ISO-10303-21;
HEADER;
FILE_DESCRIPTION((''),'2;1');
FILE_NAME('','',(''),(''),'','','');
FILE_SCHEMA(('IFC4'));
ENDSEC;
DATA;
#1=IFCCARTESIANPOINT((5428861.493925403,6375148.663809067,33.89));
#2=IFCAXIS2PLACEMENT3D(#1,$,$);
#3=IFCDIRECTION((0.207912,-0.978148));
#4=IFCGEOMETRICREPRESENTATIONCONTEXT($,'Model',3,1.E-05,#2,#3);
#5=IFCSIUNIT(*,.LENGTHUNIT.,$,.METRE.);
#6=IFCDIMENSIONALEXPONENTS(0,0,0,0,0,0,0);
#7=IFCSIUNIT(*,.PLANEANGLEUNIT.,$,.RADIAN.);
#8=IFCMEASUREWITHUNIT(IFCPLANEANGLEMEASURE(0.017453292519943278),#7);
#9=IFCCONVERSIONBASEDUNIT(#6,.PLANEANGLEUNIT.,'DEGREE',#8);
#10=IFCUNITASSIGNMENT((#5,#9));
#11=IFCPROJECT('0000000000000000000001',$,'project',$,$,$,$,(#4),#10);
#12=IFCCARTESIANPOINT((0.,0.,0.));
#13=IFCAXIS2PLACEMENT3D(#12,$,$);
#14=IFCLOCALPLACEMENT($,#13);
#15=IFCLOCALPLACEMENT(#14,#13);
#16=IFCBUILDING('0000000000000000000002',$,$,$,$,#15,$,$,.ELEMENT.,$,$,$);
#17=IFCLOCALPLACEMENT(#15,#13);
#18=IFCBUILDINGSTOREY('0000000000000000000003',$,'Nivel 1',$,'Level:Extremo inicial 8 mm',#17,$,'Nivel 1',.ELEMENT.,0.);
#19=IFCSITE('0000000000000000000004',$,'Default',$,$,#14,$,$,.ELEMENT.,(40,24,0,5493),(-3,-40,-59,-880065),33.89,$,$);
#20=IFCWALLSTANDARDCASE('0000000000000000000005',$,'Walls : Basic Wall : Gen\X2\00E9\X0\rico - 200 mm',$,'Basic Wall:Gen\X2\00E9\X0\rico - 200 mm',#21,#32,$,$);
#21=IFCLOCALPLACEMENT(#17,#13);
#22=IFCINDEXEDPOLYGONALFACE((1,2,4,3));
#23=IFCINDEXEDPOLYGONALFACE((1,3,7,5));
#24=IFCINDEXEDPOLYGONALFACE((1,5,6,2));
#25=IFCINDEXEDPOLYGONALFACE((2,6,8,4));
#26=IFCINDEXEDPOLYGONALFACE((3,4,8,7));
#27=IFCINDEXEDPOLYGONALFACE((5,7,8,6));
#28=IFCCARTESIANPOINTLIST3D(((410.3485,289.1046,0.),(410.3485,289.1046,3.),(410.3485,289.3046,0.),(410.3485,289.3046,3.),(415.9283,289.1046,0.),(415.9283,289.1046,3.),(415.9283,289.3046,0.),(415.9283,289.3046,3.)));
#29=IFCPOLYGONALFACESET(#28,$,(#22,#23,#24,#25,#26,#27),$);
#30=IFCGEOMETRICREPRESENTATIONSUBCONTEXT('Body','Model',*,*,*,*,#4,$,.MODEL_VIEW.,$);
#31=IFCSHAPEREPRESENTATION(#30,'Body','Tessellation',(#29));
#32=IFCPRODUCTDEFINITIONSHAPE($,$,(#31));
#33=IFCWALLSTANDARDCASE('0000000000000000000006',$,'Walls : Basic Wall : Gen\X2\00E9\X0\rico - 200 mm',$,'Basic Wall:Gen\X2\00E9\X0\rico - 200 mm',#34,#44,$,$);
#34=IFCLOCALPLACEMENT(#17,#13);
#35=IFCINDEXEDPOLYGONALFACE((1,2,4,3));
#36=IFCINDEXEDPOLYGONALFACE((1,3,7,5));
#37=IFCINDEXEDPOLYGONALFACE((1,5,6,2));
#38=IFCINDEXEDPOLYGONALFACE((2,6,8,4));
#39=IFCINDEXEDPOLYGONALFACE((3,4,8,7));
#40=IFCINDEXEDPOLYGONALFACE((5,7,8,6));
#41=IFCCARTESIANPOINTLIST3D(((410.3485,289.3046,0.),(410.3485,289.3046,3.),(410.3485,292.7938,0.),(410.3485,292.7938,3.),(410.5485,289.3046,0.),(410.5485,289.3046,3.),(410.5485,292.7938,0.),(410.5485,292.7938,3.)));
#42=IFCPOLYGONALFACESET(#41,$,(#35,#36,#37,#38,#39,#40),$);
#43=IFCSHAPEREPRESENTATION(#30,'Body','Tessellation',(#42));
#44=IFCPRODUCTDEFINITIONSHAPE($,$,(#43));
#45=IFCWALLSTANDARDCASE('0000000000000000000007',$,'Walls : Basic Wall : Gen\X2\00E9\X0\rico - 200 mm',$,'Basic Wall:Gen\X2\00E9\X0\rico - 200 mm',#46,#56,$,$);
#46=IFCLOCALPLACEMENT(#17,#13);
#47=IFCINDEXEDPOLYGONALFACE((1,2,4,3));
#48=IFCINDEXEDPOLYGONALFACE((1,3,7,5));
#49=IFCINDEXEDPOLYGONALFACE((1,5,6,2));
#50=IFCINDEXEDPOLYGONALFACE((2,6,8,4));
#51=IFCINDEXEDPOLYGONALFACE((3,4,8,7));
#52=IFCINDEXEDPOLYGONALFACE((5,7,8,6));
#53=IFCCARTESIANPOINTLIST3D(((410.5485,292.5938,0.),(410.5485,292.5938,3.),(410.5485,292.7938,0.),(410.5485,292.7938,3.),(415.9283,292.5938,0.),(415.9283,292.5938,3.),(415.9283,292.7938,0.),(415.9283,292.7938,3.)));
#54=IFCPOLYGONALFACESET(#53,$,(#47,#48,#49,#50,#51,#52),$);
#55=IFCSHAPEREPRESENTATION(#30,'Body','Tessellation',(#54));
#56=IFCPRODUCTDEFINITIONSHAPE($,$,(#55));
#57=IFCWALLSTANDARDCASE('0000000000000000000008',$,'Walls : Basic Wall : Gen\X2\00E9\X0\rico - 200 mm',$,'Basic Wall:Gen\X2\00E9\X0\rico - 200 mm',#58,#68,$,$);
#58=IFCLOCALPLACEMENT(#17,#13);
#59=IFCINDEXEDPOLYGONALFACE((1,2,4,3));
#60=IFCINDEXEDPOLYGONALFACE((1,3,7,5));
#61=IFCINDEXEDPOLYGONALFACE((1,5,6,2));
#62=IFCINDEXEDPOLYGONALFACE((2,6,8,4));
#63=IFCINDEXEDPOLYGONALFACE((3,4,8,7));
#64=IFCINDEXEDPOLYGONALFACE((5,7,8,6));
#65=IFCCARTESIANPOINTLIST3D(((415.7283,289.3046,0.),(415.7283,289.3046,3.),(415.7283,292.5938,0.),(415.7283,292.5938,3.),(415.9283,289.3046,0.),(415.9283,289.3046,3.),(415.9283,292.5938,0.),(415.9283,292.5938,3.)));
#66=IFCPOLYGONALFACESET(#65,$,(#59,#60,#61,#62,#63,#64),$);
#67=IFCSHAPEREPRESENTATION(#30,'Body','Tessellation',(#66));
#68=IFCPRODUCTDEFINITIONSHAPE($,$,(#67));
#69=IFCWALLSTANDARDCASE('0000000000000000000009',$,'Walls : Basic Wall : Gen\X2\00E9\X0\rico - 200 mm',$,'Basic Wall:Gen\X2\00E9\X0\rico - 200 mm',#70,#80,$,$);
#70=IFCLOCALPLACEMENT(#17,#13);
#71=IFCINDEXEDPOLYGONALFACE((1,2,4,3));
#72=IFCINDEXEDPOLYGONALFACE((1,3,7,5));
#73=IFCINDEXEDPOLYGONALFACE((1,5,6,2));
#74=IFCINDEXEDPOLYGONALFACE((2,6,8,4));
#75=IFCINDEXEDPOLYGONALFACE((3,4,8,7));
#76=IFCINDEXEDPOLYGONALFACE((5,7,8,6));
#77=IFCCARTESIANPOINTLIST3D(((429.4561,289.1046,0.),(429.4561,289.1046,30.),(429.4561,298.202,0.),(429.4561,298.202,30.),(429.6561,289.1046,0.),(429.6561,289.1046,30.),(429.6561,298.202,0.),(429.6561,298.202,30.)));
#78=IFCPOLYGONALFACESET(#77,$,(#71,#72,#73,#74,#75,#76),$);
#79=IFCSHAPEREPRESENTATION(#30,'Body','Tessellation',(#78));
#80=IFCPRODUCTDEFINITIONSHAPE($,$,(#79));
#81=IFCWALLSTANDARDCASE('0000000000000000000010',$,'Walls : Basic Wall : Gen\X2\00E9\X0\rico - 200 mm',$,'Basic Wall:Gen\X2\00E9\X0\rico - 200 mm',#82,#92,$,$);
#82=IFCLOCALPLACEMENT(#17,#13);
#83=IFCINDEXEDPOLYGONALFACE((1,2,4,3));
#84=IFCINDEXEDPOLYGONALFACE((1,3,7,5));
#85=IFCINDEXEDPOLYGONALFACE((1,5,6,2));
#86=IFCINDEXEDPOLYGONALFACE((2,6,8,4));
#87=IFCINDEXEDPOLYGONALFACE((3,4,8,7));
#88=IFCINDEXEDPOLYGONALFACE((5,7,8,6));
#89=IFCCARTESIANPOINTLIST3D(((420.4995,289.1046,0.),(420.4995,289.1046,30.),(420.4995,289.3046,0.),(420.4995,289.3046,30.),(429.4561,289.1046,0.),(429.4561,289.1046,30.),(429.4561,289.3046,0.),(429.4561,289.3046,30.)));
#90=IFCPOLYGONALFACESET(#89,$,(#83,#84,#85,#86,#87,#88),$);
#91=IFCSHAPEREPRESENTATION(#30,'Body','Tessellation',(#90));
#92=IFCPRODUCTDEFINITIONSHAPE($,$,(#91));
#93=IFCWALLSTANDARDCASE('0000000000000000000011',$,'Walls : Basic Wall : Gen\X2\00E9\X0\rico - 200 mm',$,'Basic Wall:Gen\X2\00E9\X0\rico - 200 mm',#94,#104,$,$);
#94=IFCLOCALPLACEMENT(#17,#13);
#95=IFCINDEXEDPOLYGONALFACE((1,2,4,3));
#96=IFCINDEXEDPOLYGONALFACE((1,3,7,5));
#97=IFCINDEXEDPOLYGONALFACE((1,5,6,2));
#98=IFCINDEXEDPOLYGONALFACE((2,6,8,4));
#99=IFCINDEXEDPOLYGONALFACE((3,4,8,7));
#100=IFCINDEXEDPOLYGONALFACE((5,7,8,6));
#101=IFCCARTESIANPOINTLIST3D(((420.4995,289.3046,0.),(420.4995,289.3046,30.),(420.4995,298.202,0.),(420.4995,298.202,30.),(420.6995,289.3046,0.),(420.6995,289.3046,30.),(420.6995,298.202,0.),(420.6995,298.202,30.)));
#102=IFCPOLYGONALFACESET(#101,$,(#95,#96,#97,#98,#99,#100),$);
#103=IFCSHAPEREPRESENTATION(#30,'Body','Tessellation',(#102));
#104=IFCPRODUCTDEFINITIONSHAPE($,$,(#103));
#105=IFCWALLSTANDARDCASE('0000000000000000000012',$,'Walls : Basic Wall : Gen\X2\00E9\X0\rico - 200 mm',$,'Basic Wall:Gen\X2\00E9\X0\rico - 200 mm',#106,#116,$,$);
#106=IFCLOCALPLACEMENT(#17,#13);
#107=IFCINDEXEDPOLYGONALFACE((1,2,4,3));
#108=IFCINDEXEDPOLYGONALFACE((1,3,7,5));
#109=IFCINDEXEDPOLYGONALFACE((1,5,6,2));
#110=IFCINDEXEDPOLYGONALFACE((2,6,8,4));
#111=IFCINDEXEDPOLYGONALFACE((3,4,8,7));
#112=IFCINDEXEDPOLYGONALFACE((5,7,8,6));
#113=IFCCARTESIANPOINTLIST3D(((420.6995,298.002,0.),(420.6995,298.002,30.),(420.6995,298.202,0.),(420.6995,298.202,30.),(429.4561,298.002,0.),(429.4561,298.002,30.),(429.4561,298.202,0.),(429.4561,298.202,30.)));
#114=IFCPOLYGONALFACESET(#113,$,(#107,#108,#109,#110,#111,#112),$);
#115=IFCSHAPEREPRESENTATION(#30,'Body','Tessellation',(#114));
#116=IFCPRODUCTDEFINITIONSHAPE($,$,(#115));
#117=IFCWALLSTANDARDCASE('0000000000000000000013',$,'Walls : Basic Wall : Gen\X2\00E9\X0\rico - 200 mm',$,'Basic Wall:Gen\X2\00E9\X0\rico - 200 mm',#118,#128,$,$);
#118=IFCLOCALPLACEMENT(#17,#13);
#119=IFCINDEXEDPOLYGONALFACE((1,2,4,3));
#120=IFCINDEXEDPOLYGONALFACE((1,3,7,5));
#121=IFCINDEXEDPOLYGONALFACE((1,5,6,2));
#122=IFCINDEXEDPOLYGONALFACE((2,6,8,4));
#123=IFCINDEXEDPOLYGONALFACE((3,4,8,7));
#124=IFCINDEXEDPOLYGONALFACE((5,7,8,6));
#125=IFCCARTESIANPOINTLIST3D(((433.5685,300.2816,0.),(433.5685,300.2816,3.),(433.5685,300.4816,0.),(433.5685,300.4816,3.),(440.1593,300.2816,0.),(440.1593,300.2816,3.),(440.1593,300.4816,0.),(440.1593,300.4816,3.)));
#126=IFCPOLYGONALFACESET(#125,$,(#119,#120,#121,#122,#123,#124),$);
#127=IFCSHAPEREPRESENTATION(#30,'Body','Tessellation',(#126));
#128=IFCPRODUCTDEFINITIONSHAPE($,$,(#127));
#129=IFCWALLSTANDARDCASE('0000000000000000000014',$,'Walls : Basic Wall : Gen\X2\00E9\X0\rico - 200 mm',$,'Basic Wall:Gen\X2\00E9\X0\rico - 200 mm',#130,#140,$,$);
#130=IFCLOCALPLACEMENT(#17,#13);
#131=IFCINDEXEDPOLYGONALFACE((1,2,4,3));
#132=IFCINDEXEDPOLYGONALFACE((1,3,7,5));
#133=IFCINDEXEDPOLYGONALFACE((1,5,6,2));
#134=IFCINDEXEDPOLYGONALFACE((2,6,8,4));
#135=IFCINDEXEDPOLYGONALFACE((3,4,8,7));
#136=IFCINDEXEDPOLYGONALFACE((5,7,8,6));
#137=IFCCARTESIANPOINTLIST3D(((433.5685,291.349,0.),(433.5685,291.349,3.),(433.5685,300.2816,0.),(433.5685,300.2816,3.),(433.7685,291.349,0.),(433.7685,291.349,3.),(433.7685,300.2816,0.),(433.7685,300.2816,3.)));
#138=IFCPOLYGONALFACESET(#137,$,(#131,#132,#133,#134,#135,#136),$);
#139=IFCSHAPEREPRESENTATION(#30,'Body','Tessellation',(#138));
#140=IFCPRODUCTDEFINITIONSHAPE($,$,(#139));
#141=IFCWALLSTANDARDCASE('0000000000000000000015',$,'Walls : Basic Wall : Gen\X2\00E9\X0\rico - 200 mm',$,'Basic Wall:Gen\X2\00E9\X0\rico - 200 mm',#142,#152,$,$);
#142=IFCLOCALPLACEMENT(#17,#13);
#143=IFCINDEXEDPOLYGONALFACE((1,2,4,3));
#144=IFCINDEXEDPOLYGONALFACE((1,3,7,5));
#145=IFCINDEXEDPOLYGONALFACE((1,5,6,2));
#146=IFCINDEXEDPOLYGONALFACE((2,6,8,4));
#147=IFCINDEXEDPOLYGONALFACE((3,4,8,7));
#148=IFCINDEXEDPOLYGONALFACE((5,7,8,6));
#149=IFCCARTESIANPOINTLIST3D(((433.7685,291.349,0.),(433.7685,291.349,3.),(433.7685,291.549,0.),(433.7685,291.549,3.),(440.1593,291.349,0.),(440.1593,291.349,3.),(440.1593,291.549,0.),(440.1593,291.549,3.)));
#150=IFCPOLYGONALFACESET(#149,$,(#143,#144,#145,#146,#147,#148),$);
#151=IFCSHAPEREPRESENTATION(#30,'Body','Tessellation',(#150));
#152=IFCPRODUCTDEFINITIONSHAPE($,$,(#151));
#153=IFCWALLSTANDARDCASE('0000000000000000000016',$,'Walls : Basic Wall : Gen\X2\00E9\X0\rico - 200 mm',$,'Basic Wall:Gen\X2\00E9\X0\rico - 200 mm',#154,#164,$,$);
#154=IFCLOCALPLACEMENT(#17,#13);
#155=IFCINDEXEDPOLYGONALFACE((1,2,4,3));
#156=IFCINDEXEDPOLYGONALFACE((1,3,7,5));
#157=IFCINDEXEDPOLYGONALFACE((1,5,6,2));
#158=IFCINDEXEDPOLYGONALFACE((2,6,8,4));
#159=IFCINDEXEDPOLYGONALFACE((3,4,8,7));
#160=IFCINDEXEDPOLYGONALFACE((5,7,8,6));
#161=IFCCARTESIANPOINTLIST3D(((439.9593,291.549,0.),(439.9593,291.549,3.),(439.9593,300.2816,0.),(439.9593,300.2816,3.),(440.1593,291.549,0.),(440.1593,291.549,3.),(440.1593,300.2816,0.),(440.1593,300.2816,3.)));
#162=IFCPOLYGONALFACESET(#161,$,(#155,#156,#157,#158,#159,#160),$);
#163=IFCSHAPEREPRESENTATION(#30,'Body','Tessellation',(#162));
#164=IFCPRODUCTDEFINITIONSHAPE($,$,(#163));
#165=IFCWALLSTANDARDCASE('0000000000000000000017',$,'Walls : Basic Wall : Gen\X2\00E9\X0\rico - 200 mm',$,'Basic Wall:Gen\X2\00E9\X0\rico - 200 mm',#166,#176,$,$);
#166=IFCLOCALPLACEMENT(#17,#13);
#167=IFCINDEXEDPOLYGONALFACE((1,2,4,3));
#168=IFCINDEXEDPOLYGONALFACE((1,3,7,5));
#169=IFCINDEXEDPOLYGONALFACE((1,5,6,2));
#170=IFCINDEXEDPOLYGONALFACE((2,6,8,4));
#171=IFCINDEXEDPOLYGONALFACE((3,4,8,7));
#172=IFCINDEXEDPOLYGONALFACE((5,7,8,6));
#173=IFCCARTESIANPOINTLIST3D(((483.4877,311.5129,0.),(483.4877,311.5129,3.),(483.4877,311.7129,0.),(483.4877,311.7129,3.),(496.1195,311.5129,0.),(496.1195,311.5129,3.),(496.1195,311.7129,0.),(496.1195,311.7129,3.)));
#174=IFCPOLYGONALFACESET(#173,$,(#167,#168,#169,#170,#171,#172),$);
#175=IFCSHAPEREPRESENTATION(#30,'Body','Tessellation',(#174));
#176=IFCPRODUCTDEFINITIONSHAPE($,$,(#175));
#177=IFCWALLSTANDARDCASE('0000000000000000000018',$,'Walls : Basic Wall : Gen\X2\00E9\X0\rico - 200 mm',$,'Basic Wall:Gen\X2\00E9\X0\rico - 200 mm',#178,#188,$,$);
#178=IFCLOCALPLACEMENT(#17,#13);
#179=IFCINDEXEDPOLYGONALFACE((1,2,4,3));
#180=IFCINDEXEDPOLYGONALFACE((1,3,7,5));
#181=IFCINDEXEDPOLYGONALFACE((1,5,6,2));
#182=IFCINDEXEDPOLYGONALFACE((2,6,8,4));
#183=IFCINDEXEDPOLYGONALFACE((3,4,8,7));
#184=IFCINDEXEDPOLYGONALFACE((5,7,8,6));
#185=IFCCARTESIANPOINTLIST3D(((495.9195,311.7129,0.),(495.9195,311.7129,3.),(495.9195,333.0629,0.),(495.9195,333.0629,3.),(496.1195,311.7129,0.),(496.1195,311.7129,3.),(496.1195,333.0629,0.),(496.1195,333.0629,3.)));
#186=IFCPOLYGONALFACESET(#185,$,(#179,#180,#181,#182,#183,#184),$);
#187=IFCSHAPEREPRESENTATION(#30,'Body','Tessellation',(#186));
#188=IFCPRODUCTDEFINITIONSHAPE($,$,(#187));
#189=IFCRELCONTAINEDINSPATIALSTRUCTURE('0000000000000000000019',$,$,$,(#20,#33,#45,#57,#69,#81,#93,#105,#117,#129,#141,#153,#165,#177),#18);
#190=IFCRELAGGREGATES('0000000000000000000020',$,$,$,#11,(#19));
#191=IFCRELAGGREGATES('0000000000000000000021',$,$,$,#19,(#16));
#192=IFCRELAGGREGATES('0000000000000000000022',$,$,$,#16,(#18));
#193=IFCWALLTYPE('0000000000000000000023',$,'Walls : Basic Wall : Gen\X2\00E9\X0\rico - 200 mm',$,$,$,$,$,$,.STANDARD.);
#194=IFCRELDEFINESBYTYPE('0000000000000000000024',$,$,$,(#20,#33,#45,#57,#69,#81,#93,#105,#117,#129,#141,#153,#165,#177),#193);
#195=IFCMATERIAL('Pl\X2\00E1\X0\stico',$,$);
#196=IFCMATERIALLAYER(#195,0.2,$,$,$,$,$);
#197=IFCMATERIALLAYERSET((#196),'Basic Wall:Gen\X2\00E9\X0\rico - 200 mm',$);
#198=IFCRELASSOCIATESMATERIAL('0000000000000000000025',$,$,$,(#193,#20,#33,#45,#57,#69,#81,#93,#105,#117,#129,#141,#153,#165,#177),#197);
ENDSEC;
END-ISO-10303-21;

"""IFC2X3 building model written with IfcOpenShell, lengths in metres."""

from ifc_helpers import new_model, entity, si_unit, converted_unit, direction, frame, frame_2d, origin, place, context, subcontext, project, spatial, rectangle, extrude, material, layer, layer_set, layer_usage, type_object, element, save


model = new_model("IFC2X3")

# Units and contexts
model_context = context("Model", 3, precision=1e-05, world=frame((5428861.493925403, 6375148.663809067, 33.89)), true_north=direction((0.207912, -0.978148)))
body_context = subcontext(model_context, "Body", "Model", "MODEL_VIEW")
ifc_project = project(units=[si_unit("LENGTHUNIT", "METRE"), converted_unit("PLANEANGLEUNIT", "DEGREE", entity("IfcPlaneAngleMeasure", 0.017453292519943278), si_unit("PLANEANGLEUNIT", "RADIAN"), dimensions=[0, 0, 0, 0, 0, 0, 0])], contexts=[model_context])

# Site, building, storey
site_placement = place(None, origin())
site = spatial("IfcSite", under=ifc_project, at=site_placement, Name="Default", CompositionType="ELEMENT", RefLatitude=(40, 24, 0, 5493), RefLongitude=(-3, -40, -59, -880065), RefElevation=33.89)
building_placement = place(site_placement, origin())
building = spatial("IfcBuilding", under=site, at=building_placement, CompositionType="ELEMENT")
storey_placement = place(building_placement, origin())
storey = spatial("IfcBuildingStorey", under=building, at=storey_placement, Name="Nivel 1", ObjectType="Level:Extremo inicial 8 mm", LongName="Nivel 1", CompositionType="ELEMENT", Elevation=0.0)

# Walls
ifc_material = material(Name="Plástico")
ifc_layer = layer(ifc_material, 0.2)
ifc_layer_set = layer_set([ifc_layer], Name="Basic Wall:Genérico - 200 mm")
wall_type = type_object("IfcWallType", Name="Walls : Basic Wall : Genérico - 200 mm", PredefinedType="STANDARD", material=ifc_layer_set)
ifc_layer_usage_1 = layer_usage(ifc_layer_set, "AXIS2", "NEGATIVE", 0.1)
wall_1_placement = place(storey_placement, frame((415.9283, 289.2046, 0.0), z_axis=(0.0, 0.0, 1.0), x_axis=(-1.0, 0.0, 0.0)))
element("IfcWallStandardCase", 1, at=wall_1_placement, inside=storey, type_object=wall_type, material=ifc_layer_usage_1, Name="Walls : Basic Wall : Genérico - 200 mm", ObjectType="Basic Wall:Genérico - 200 mm", context=body_context, shape_type="SweptSolid", body=[
    extrude(rectangle(XDim=5.5799, YDim=0.2, at=frame_2d((2.7899, 0.0), x_axis=(-1.0, 0.0))), origin(), (0.0, 0.0, 1.0), 3.0),
])
ifc_layer_usage_2 = layer_usage(ifc_layer_set, "AXIS2", "NEGATIVE", 0.1)
wall_2_placement = place(storey_placement, frame((410.4485, 289.3046, 0.0), z_axis=(0.0, 0.0, 1.0), x_axis=(0.0, 1.0, 0.0)))
element("IfcWallStandardCase", 2, at=wall_2_placement, inside=storey, type_object=wall_type, material=ifc_layer_usage_2, Name="Walls : Basic Wall : Genérico - 200 mm", ObjectType="Basic Wall:Genérico - 200 mm", context=body_context, shape_type="SweptSolid", body=[
    extrude(rectangle(XDim=3.4892, YDim=0.2, at=frame_2d((1.7446, 0.0), x_axis=(-1.0, 0.0))), origin(), (0.0, 0.0, 1.0), 3.0),
])
ifc_layer_usage_3 = layer_usage(ifc_layer_set, "AXIS2", "NEGATIVE", 0.1)
wall_3_placement = place(storey_placement, frame((410.5485, 292.6938, 0.0)))
element("IfcWallStandardCase", 3, at=wall_3_placement, inside=storey, type_object=wall_type, material=ifc_layer_usage_3, Name="Walls : Basic Wall : Genérico - 200 mm", ObjectType="Basic Wall:Genérico - 200 mm", context=body_context, shape_type="SweptSolid", body=[
    extrude(rectangle(XDim=5.3799, YDim=0.2, at=frame_2d((2.6899, 0.0), x_axis=(-1.0, 0.0))), origin(), (0.0, 0.0, 1.0), 3.0),
])
ifc_layer_usage_4 = layer_usage(ifc_layer_set, "AXIS2", "NEGATIVE", 0.1)
wall_4_placement = place(storey_placement, frame((415.8283, 292.5938, 0.0), z_axis=(0.0, 0.0, 1.0), x_axis=(0.0, -1.0, 0.0)))
element("IfcWallStandardCase", 4, at=wall_4_placement, inside=storey, type_object=wall_type, material=ifc_layer_usage_4, Name="Walls : Basic Wall : Genérico - 200 mm", ObjectType="Basic Wall:Genérico - 200 mm", context=body_context, shape_type="SweptSolid", body=[
    extrude(rectangle(XDim=3.2892, YDim=0.2, at=frame_2d((1.6446, 0.0), x_axis=(-1.0, 0.0))), origin(), (0.0, 0.0, 1.0), 3.0),
])
ifc_layer_usage_5 = layer_usage(ifc_layer_set, "AXIS2", "NEGATIVE", 0.1)
wall_5_placement = place(storey_placement, frame((429.5561, 298.202, 0.0), z_axis=(0.0, 0.0, 1.0), x_axis=(0.0, -1.0, 0.0)))
element("IfcWallStandardCase", 5, at=wall_5_placement, inside=storey, type_object=wall_type, material=ifc_layer_usage_5, Name="Walls : Basic Wall : Genérico - 200 mm", ObjectType="Basic Wall:Genérico - 200 mm", context=body_context, shape_type="SweptSolid", body=[
    extrude(rectangle(XDim=9.0973, YDim=0.2, at=frame_2d((4.5487, 0.0), x_axis=(-1.0, 0.0))), origin(), (0.0, 0.0, 1.0), 30.0),
])
ifc_layer_usage_6 = layer_usage(ifc_layer_set, "AXIS2", "NEGATIVE", 0.1)
wall_6_placement = place(storey_placement, frame((429.4561, 289.2046, 0.0), z_axis=(0.0, 0.0, 1.0), x_axis=(-1.0, 0.0, 0.0)))
element("IfcWallStandardCase", 6, at=wall_6_placement, inside=storey, type_object=wall_type, material=ifc_layer_usage_6, Name="Walls : Basic Wall : Genérico - 200 mm", ObjectType="Basic Wall:Genérico - 200 mm", context=body_context, shape_type="SweptSolid", body=[
    extrude(rectangle(XDim=8.9566, YDim=0.2, at=frame_2d((4.4783, 0.0), x_axis=(-1.0, 0.0))), origin(), (0.0, 0.0, 1.0), 30.0),
])
ifc_layer_usage_7 = layer_usage(ifc_layer_set, "AXIS2", "NEGATIVE", 0.1)
wall_7_placement = place(storey_placement, frame((420.5995, 289.3046, 0.0), z_axis=(0.0, 0.0, 1.0), x_axis=(0.0, 1.0, 0.0)))
element("IfcWallStandardCase", 7, at=wall_7_placement, inside=storey, type_object=wall_type, material=ifc_layer_usage_7, Name="Walls : Basic Wall : Genérico - 200 mm", ObjectType="Basic Wall:Genérico - 200 mm", context=body_context, shape_type="SweptSolid", body=[
    extrude(rectangle(XDim=8.8973, YDim=0.2, at=frame_2d((4.4487, 0.0), x_axis=(-1.0, 0.0))), origin(), (0.0, 0.0, 1.0), 30.0),
])
ifc_layer_usage_8 = layer_usage(ifc_layer_set, "AXIS2", "NEGATIVE", 0.1)
wall_8_placement = place(storey_placement, frame((420.6995, 298.102, 0.0)))
element("IfcWallStandardCase", 8, at=wall_8_placement, inside=storey, type_object=wall_type, material=ifc_layer_usage_8, Name="Walls : Basic Wall : Genérico - 200 mm", ObjectType="Basic Wall:Genérico - 200 mm", context=body_context, shape_type="SweptSolid", body=[
    extrude(rectangle(XDim=8.7566, YDim=0.2, at=frame_2d((4.3783, 0.0), x_axis=(-1.0, 0.0))), origin(), (0.0, 0.0, 1.0), 30.0),
])
ifc_layer_usage_9 = layer_usage(ifc_layer_set, "AXIS2", "NEGATIVE", 0.1)
wall_9_placement = place(storey_placement, frame((440.1593, 300.3816, 0.0), z_axis=(0.0, 0.0, 1.0), x_axis=(-1.0, 0.0, 0.0)))
element("IfcWallStandardCase", 9, at=wall_9_placement, inside=storey, type_object=wall_type, material=ifc_layer_usage_9, Name="Walls : Basic Wall : Genérico - 200 mm", ObjectType="Basic Wall:Genérico - 200 mm", context=body_context, shape_type="SweptSolid", body=[
    extrude(rectangle(XDim=6.5908, YDim=0.2, at=frame_2d((3.2954, 0.0), x_axis=(-1.0, 0.0))), origin(), (0.0, 0.0, 1.0), 3.0),
])
ifc_layer_usage_10 = layer_usage(ifc_layer_set, "AXIS2", "NEGATIVE", 0.1)
wall_10_placement = place(storey_placement, frame((433.6685, 300.2816, 0.0), z_axis=(0.0, 0.0, 1.0), x_axis=(0.0, -1.0, 0.0)))
element("IfcWallStandardCase", 10, at=wall_10_placement, inside=storey, type_object=wall_type, material=ifc_layer_usage_10, Name="Walls : Basic Wall : Genérico - 200 mm", ObjectType="Basic Wall:Genérico - 200 mm", context=body_context, shape_type="SweptSolid", body=[
    extrude(rectangle(XDim=8.9326, YDim=0.2, at=frame_2d((4.4663, 0.0), x_axis=(-1.0, 0.0))), origin(), (0.0, 0.0, 1.0), 3.0),
])
ifc_layer_usage_11 = layer_usage(ifc_layer_set, "AXIS2", "NEGATIVE", 0.1)
wall_11_placement = place(storey_placement, frame((433.7685, 291.449, 0.0)))
element("IfcWallStandardCase", 11, at=wall_11_placement, inside=storey, type_object=wall_type, material=ifc_layer_usage_11, Name="Walls : Basic Wall : Genérico - 200 mm", ObjectType="Basic Wall:Genérico - 200 mm", context=body_context, shape_type="SweptSolid", body=[
    extrude(rectangle(XDim=6.3908, YDim=0.2, at=frame_2d((3.1954, 0.0), x_axis=(-1.0, 0.0))), origin(), (0.0, 0.0, 1.0), 3.0),
])
ifc_layer_usage_12 = layer_usage(ifc_layer_set, "AXIS2", "NEGATIVE", 0.1)
wall_12_placement = place(storey_placement, frame((440.0593, 291.549, 0.0), z_axis=(0.0, 0.0, 1.0), x_axis=(0.0, 1.0, 0.0)))
element("IfcWallStandardCase", 12, at=wall_12_placement, inside=storey, type_object=wall_type, material=ifc_layer_usage_12, Name="Walls : Basic Wall : Genérico - 200 mm", ObjectType="Basic Wall:Genérico - 200 mm", context=body_context, shape_type="SweptSolid", body=[
    extrude(rectangle(XDim=8.7326, YDim=0.2, at=frame_2d((4.3663, 0.0), x_axis=(-1.0, 0.0))), origin(), (0.0, 0.0, 1.0), 3.0),
])
ifc_layer_usage_13 = layer_usage(ifc_layer_set, "AXIS2", "NEGATIVE", 0.1)
wall_13_placement = place(storey_placement, frame((483.4877, 311.6129, 0.0)))
element("IfcWallStandardCase", 13, at=wall_13_placement, inside=storey, type_object=wall_type, material=ifc_layer_usage_13, Name="Walls : Basic Wall : Genérico - 200 mm", ObjectType="Basic Wall:Genérico - 200 mm", context=body_context, shape_type="SweptSolid", body=[
    extrude(rectangle(XDim=12.6318, YDim=0.2, at=frame_2d((6.3159, 0.0), x_axis=(-1.0, 0.0))), origin(), (0.0, 0.0, 1.0), 3.0),
])
ifc_layer_usage_14 = layer_usage(ifc_layer_set, "AXIS2", "NEGATIVE", 0.1)
wall_14_placement = place(storey_placement, frame((496.0195, 311.7129, 0.0), z_axis=(0.0, 0.0, 1.0), x_axis=(0.0, 1.0, 0.0)))
element("IfcWallStandardCase", 14, at=wall_14_placement, inside=storey, type_object=wall_type, material=ifc_layer_usage_14, Name="Walls : Basic Wall : Genérico - 200 mm", ObjectType="Basic Wall:Genérico - 200 mm", context=body_context, shape_type="SweptSolid", body=[
    extrude(rectangle(XDim=21.3499, YDim=0.2, at=frame_2d((10.675, 0.0), x_axis=(-1.0, 0.0))), origin(), (0.0, 0.0, 1.0), 3.0),
])

save(model, "model.ifc")
